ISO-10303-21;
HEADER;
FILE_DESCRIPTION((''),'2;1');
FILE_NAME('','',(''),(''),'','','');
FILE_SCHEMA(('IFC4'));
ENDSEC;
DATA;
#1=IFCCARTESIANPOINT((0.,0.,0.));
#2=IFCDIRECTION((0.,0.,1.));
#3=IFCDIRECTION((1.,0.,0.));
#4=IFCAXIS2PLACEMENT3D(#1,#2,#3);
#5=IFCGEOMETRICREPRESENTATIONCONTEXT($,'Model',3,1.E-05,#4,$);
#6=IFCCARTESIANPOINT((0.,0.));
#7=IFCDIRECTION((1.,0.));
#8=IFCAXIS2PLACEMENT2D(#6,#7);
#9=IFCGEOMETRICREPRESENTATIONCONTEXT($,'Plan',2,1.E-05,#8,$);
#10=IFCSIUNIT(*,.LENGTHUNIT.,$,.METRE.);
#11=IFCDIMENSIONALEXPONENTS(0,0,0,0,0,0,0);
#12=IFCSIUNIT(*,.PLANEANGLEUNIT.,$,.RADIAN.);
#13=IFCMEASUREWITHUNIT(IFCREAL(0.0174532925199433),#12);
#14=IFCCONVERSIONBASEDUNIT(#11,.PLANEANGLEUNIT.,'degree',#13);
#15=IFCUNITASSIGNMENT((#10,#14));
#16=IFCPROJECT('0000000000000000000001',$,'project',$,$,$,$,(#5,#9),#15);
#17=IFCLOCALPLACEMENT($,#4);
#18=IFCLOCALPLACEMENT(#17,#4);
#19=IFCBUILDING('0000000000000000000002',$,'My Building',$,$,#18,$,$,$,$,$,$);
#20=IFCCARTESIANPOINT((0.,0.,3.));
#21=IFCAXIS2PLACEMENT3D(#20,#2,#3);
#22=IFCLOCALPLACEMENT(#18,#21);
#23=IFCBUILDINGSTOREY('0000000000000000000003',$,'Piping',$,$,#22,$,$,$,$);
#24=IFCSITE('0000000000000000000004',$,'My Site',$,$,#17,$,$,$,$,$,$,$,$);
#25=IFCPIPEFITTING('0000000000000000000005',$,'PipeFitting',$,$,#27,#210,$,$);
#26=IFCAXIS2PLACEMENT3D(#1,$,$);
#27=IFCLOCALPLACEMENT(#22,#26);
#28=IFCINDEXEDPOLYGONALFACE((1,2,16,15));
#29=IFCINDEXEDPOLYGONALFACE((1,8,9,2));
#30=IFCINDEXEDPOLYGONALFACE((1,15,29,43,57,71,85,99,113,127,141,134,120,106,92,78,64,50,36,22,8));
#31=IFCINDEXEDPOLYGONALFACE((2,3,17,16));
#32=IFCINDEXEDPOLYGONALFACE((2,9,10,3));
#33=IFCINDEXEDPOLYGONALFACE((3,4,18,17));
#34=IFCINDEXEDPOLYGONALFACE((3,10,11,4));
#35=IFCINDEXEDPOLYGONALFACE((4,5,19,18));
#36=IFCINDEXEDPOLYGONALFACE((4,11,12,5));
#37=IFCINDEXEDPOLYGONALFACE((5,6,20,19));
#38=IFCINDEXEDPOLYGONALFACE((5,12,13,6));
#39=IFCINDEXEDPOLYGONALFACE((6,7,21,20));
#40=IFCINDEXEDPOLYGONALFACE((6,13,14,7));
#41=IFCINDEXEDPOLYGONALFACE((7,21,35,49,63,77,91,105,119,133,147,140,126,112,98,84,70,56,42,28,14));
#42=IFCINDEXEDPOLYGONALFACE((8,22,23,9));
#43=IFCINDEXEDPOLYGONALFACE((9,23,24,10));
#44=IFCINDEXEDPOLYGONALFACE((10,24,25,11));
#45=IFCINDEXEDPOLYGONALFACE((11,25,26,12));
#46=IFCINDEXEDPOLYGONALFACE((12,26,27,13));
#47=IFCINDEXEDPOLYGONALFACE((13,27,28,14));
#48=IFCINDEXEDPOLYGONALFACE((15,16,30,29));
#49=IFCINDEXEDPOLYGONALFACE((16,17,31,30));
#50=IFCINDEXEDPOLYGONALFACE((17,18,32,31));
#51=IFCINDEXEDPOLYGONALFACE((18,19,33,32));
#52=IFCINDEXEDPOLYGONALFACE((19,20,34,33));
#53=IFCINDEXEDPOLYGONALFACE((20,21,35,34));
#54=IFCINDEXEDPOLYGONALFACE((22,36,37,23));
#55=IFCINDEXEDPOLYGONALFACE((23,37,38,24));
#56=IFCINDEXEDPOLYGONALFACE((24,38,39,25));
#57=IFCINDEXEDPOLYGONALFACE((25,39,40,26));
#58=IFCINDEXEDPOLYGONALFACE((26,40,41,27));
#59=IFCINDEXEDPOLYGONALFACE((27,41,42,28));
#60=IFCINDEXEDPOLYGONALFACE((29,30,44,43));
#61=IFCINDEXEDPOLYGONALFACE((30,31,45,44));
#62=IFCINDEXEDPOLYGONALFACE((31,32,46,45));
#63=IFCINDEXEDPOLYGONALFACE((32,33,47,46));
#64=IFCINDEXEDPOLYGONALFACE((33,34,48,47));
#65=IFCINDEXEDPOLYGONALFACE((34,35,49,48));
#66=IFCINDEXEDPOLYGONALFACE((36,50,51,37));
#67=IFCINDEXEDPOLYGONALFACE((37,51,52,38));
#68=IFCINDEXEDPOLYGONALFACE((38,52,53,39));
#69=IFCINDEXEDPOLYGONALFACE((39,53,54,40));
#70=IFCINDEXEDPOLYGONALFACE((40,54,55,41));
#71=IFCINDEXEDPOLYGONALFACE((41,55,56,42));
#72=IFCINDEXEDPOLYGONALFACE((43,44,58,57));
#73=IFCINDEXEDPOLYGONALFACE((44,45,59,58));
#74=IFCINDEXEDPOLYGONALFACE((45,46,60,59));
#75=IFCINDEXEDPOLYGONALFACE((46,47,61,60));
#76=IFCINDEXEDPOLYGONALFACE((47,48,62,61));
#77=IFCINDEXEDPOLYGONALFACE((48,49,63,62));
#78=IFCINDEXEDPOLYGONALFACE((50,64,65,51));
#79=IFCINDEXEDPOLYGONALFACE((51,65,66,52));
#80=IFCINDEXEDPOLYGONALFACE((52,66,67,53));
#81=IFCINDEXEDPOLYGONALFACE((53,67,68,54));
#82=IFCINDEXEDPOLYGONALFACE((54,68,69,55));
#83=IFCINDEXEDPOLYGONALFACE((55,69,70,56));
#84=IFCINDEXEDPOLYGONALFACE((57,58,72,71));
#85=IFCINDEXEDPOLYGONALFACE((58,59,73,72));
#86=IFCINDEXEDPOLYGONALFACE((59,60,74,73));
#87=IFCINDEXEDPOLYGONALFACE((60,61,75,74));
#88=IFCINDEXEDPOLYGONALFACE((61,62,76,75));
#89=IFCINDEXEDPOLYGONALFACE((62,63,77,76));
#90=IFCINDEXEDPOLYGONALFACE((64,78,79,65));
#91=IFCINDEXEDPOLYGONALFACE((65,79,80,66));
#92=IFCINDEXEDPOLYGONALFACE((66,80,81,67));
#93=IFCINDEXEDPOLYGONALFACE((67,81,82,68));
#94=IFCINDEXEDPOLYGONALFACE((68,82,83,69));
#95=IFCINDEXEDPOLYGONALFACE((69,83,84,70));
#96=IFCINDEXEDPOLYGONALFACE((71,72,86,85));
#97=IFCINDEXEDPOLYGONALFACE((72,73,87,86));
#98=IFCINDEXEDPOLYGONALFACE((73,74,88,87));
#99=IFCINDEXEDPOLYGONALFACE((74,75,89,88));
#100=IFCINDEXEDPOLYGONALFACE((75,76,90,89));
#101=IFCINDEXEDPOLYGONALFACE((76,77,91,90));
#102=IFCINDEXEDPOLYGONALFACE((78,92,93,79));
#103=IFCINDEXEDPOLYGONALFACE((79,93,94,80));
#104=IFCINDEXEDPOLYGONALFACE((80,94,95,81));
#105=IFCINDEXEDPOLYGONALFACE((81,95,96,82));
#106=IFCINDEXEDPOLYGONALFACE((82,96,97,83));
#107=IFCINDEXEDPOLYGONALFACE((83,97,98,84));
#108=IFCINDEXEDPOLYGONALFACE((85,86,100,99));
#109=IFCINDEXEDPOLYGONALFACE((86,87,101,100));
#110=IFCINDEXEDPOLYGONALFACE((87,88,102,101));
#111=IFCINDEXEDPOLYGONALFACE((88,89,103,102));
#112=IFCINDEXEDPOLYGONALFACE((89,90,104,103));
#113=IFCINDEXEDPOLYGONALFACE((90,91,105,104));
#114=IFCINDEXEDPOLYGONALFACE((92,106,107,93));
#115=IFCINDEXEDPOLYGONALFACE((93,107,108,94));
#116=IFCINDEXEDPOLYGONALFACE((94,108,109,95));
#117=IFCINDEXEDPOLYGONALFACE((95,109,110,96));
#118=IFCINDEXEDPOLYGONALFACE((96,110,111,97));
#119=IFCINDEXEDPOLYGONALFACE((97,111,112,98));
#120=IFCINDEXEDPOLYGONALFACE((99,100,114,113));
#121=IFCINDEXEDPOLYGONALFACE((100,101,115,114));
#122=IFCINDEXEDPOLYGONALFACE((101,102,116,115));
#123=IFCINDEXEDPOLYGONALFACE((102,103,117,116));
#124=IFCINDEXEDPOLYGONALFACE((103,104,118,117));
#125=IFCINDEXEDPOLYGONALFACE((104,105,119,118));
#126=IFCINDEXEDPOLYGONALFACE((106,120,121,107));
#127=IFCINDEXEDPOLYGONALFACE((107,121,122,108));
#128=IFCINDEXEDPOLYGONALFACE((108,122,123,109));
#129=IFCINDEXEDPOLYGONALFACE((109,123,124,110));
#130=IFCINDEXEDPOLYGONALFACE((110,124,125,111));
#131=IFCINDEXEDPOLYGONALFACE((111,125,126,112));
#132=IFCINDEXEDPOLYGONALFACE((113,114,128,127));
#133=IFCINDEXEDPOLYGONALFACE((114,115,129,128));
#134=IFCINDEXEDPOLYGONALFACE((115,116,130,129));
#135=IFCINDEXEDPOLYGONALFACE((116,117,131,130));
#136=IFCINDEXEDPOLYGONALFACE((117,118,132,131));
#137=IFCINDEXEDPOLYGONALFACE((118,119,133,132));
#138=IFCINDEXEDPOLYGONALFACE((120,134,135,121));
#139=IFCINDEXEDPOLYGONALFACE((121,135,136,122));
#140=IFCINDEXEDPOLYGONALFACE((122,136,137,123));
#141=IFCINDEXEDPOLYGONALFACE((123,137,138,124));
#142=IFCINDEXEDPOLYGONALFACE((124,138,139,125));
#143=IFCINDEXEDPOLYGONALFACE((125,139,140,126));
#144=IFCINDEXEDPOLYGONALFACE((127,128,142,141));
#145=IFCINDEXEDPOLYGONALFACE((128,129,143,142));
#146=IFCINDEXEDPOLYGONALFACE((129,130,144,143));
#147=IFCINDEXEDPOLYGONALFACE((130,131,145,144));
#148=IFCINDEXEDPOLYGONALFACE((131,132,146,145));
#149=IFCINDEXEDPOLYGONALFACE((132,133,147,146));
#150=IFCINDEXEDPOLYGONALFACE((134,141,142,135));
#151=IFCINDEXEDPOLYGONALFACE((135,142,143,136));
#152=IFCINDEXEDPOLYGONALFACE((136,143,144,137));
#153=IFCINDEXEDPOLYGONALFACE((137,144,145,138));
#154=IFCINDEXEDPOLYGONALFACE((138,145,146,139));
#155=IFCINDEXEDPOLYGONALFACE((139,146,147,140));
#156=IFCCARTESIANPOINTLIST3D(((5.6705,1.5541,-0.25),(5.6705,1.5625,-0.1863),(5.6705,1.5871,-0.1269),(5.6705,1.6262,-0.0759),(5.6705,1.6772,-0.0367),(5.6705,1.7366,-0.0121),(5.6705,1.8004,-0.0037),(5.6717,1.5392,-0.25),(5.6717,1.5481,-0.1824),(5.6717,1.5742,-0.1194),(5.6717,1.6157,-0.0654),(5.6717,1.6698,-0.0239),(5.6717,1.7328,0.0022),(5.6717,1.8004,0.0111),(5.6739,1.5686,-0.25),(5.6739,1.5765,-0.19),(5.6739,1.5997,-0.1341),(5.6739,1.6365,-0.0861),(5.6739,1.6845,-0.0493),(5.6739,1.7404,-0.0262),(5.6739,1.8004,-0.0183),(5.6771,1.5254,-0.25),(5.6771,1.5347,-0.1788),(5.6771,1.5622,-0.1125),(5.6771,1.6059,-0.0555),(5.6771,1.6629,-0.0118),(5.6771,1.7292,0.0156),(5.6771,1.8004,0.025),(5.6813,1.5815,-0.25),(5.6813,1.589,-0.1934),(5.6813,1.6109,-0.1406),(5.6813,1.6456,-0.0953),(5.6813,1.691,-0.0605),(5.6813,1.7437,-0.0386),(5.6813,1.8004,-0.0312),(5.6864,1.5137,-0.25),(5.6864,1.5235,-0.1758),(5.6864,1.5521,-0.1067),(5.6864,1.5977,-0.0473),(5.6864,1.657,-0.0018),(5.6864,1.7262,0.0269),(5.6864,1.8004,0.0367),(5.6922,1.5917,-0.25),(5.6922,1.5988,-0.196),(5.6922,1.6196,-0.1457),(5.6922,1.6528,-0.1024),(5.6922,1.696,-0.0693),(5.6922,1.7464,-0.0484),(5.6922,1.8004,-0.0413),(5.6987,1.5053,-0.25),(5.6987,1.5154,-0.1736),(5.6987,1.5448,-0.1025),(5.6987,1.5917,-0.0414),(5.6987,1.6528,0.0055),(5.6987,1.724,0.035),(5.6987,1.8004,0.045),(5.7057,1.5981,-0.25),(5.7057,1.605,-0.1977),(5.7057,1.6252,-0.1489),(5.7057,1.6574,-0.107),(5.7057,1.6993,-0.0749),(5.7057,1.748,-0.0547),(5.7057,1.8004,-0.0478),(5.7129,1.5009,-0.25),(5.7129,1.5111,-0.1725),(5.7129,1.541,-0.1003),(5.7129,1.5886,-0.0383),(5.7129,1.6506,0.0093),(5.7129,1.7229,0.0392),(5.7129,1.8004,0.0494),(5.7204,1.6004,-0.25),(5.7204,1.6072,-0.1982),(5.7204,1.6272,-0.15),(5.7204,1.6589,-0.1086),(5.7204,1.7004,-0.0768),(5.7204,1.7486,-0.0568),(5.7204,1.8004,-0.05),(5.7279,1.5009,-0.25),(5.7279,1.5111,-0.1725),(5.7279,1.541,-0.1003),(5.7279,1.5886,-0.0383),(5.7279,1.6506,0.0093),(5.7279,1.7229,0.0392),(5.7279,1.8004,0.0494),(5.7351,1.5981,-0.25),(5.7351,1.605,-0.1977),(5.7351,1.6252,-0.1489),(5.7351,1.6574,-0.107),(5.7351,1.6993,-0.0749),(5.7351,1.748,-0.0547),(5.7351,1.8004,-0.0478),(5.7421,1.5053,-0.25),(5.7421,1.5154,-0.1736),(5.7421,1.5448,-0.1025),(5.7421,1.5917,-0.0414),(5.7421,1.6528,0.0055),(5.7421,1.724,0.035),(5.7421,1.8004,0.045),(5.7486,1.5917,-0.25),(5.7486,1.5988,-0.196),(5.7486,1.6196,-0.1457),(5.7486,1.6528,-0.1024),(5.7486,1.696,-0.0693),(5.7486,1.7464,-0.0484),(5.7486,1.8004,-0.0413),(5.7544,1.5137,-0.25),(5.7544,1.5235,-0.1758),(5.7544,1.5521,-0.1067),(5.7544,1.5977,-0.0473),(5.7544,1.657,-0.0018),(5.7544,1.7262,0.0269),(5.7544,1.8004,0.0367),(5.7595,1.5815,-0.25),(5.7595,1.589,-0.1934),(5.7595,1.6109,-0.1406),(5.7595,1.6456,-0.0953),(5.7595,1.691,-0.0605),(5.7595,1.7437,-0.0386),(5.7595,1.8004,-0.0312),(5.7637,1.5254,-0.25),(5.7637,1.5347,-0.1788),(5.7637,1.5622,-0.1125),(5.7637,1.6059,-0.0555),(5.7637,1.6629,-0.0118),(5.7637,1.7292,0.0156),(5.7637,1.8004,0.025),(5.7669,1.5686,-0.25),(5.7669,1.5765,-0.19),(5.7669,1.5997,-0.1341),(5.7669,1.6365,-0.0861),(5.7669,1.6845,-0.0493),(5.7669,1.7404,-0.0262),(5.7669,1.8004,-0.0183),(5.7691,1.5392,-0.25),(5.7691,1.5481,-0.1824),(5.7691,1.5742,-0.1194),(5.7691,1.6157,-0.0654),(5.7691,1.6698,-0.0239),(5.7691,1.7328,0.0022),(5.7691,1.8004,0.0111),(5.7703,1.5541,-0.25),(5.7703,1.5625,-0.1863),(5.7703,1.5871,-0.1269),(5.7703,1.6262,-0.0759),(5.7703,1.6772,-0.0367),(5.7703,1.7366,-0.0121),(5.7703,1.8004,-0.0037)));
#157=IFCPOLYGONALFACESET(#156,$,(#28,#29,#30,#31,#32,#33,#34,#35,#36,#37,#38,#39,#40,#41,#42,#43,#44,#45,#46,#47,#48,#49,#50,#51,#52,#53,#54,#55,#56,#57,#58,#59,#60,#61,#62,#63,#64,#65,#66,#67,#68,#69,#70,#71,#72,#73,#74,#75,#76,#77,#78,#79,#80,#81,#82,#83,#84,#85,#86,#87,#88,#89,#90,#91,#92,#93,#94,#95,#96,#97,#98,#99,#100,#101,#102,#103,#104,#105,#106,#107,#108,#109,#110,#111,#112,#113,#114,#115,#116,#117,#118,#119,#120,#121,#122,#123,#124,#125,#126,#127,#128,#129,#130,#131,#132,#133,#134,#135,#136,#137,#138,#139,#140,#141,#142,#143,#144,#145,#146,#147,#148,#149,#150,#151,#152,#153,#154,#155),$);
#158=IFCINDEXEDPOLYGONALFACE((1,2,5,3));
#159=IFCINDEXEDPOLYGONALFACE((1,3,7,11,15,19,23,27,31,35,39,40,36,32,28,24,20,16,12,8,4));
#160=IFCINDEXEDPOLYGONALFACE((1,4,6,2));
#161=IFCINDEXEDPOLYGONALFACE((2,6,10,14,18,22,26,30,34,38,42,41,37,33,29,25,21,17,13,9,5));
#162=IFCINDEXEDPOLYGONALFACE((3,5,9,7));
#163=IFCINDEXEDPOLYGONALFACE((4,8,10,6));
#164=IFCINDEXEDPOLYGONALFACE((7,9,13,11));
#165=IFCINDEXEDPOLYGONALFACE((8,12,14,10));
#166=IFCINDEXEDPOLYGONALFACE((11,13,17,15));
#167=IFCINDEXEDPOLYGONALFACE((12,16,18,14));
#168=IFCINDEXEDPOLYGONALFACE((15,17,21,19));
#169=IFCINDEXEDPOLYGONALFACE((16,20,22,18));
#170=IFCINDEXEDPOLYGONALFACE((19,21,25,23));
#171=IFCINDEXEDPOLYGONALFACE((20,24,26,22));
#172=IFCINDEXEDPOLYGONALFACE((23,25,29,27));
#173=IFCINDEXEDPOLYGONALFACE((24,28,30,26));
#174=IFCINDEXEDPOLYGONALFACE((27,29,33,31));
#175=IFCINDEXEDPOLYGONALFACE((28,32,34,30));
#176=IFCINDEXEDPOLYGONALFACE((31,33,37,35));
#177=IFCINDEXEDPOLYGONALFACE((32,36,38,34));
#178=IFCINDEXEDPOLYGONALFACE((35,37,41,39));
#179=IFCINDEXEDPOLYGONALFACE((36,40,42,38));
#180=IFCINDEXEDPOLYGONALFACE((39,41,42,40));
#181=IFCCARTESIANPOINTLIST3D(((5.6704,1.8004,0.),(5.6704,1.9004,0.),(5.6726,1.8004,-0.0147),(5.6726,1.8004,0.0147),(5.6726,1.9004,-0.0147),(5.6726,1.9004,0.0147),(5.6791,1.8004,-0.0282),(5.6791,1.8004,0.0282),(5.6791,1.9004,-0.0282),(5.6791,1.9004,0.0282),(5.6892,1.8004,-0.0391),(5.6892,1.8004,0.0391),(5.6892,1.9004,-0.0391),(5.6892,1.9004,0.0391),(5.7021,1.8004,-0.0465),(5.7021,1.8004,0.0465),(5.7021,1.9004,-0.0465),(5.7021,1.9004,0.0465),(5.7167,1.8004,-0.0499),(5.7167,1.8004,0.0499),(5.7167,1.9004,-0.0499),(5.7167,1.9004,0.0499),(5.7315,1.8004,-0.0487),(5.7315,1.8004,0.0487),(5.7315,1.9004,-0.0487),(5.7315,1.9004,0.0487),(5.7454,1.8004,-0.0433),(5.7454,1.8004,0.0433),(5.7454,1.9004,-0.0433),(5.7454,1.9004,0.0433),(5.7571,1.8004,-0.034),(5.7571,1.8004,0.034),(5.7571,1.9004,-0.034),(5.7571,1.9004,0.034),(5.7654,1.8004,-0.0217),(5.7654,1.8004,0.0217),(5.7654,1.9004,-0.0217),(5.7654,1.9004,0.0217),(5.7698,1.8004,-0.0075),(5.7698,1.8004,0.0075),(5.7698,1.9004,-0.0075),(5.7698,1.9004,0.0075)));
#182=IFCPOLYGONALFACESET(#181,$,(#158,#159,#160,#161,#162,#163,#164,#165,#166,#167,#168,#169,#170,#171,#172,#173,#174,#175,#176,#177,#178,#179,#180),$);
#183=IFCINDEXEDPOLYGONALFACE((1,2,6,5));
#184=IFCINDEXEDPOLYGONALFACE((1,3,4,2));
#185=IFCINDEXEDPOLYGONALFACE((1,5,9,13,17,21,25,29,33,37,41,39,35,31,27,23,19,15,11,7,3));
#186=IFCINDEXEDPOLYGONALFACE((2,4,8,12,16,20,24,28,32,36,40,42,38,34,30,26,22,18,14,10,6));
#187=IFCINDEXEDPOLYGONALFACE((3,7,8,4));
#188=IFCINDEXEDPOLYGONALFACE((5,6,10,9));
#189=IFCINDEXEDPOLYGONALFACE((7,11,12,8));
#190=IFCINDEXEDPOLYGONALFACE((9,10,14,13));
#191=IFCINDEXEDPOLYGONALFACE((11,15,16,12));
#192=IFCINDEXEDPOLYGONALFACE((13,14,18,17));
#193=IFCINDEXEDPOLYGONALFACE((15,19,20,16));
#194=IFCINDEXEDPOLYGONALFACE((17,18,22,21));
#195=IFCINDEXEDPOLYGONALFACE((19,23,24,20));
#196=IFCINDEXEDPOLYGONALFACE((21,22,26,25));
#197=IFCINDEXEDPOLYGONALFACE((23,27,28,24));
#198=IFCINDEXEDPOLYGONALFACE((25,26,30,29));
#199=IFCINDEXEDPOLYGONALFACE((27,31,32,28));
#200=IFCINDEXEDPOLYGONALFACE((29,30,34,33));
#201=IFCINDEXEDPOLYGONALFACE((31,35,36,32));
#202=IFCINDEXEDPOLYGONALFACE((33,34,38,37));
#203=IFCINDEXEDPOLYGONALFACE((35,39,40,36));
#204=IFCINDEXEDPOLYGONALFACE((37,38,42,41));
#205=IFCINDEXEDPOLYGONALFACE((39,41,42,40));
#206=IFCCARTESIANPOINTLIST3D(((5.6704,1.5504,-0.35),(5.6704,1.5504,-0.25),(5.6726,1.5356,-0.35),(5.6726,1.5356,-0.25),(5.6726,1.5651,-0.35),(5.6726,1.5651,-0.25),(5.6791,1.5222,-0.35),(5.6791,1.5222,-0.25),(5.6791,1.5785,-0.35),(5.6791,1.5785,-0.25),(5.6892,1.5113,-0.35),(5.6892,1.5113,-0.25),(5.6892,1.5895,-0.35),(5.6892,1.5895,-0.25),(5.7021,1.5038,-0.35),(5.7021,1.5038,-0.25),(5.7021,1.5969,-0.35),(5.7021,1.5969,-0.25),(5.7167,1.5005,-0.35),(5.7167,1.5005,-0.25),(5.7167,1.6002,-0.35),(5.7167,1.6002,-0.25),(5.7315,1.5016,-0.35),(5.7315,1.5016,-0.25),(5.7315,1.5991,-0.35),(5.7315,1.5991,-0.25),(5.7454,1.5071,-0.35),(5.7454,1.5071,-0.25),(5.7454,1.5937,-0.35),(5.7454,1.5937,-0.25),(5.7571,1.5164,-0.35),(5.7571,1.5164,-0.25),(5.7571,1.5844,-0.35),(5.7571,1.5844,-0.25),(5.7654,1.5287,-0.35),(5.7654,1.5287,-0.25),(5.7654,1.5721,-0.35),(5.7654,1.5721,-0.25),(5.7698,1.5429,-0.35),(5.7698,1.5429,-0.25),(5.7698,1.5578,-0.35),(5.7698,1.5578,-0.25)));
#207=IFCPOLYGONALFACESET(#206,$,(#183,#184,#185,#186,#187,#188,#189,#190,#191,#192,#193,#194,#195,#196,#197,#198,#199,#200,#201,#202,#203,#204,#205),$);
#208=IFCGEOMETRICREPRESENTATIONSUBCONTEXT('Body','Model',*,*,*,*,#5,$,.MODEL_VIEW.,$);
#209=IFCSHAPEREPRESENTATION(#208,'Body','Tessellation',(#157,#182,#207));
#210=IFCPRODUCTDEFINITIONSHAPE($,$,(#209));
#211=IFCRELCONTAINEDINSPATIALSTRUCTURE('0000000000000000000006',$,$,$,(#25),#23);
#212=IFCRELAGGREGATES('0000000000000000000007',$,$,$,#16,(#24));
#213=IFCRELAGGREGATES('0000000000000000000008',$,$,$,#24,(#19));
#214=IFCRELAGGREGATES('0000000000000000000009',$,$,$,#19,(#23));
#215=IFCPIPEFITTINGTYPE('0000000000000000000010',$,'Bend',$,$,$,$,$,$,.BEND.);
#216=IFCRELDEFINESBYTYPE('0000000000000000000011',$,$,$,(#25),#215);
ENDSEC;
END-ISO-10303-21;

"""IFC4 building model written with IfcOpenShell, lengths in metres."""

from ifc_helpers import new_model, entity, si_unit, converted_unit, frame, origin_with_axes, origin_2d_with_axis, place, context, subcontext, project, spatial, circle, extrude, source, transform, mapped, type_object, type_shapes, element, save


model = new_model("IFC4")

# Units and contexts
model_context = context("Model", 3, precision=1e-05, world=origin_with_axes())
plan_context = context("Plan", 2, precision=1e-05, world=origin_2d_with_axis())
body_context = subcontext(model_context, "Body", "Model", "MODEL_VIEW")
ifc_project = project(units=[si_unit("LENGTHUNIT", "METRE"), converted_unit("PLANEANGLEUNIT", "degree", entity("IfcReal", 0.0174532925199433), si_unit("PLANEANGLEUNIT", "RADIAN"), dimensions=[0, 0, 0, 0, 0, 0, 0])], contexts=[model_context, plan_context])

# Site, building, storey
site_placement = place(None, origin_with_axes())
site = spatial("IfcSite", under=ifc_project, at=site_placement, Name="My Site")
building_placement = place(site_placement, origin_with_axes())
building = spatial("IfcBuilding", under=site, at=building_placement, Name="My Building")
storey_placement = place(building_placement, frame((0.0, 0.0, 3.0), z_axis=(0.0, 0.0, 1.0), x_axis=(1.0, 0.0, 0.0)))
storey = spatial("IfcBuildingStorey", under=building, at=storey_placement, Name="Piping")

# Pipe fitting
pipe_fitting_type = type_object("IfcPipeFittingType", Name="Bend", PredefinedType="BEND")
shared_shape = source(origin_with_axes(), body_context, "Body", "SolidModel", [
    entity("IfcSweptDiskSolid", entity("IfcIndexedPolyCurve", entity("IfcCartesianPointList3D", [[0.0, 0.0, -0.1], [0.0, -0.0732, -0.2768], [0.0, -0.25, -0.35]]), [entity("IfcArcIndex", [1, 2, 3])]), 0.05),
    extrude(circle(Radius=0.05), origin_with_axes(), (0.0, 0.0, -1.0), 0.1),
    extrude(circle(Radius=0.05), frame((0.0, -0.25, -0.35), z_axis=(0.0, -1.0, 0.0), x_axis=(1.0, 0.0, 0.0)), (0.0, 0.0, 1.0), 0.1),
])
type_shapes(pipe_fitting_type, [shared_shape])
for number, where, z_axis, x_axis, name in (
    (1, (5.7204, 1.9004, 0.0), (0.0, 1.0, 0.0), (-1.0, 0.0, 0.0), "PipeFitting"),
):
    element("IfcPipeFitting", number, at=place(storey_placement, frame(where, z_axis=z_axis, x_axis=x_axis)), inside=storey, type_object=pipe_fitting_type, Name=name, context=body_context, shape_type="MappedRepresentation", body=[
        mapped(shared_shape, transform((0.0, 0.0, 0.0), x_axis=(1.0, 0.0, 0.0), y_axis=(0.0, 1.0, 0.0), z_axis=(0.0, 0.0, 1.0), scale=1.0)),
    ])

save(model, "model.ifc")
